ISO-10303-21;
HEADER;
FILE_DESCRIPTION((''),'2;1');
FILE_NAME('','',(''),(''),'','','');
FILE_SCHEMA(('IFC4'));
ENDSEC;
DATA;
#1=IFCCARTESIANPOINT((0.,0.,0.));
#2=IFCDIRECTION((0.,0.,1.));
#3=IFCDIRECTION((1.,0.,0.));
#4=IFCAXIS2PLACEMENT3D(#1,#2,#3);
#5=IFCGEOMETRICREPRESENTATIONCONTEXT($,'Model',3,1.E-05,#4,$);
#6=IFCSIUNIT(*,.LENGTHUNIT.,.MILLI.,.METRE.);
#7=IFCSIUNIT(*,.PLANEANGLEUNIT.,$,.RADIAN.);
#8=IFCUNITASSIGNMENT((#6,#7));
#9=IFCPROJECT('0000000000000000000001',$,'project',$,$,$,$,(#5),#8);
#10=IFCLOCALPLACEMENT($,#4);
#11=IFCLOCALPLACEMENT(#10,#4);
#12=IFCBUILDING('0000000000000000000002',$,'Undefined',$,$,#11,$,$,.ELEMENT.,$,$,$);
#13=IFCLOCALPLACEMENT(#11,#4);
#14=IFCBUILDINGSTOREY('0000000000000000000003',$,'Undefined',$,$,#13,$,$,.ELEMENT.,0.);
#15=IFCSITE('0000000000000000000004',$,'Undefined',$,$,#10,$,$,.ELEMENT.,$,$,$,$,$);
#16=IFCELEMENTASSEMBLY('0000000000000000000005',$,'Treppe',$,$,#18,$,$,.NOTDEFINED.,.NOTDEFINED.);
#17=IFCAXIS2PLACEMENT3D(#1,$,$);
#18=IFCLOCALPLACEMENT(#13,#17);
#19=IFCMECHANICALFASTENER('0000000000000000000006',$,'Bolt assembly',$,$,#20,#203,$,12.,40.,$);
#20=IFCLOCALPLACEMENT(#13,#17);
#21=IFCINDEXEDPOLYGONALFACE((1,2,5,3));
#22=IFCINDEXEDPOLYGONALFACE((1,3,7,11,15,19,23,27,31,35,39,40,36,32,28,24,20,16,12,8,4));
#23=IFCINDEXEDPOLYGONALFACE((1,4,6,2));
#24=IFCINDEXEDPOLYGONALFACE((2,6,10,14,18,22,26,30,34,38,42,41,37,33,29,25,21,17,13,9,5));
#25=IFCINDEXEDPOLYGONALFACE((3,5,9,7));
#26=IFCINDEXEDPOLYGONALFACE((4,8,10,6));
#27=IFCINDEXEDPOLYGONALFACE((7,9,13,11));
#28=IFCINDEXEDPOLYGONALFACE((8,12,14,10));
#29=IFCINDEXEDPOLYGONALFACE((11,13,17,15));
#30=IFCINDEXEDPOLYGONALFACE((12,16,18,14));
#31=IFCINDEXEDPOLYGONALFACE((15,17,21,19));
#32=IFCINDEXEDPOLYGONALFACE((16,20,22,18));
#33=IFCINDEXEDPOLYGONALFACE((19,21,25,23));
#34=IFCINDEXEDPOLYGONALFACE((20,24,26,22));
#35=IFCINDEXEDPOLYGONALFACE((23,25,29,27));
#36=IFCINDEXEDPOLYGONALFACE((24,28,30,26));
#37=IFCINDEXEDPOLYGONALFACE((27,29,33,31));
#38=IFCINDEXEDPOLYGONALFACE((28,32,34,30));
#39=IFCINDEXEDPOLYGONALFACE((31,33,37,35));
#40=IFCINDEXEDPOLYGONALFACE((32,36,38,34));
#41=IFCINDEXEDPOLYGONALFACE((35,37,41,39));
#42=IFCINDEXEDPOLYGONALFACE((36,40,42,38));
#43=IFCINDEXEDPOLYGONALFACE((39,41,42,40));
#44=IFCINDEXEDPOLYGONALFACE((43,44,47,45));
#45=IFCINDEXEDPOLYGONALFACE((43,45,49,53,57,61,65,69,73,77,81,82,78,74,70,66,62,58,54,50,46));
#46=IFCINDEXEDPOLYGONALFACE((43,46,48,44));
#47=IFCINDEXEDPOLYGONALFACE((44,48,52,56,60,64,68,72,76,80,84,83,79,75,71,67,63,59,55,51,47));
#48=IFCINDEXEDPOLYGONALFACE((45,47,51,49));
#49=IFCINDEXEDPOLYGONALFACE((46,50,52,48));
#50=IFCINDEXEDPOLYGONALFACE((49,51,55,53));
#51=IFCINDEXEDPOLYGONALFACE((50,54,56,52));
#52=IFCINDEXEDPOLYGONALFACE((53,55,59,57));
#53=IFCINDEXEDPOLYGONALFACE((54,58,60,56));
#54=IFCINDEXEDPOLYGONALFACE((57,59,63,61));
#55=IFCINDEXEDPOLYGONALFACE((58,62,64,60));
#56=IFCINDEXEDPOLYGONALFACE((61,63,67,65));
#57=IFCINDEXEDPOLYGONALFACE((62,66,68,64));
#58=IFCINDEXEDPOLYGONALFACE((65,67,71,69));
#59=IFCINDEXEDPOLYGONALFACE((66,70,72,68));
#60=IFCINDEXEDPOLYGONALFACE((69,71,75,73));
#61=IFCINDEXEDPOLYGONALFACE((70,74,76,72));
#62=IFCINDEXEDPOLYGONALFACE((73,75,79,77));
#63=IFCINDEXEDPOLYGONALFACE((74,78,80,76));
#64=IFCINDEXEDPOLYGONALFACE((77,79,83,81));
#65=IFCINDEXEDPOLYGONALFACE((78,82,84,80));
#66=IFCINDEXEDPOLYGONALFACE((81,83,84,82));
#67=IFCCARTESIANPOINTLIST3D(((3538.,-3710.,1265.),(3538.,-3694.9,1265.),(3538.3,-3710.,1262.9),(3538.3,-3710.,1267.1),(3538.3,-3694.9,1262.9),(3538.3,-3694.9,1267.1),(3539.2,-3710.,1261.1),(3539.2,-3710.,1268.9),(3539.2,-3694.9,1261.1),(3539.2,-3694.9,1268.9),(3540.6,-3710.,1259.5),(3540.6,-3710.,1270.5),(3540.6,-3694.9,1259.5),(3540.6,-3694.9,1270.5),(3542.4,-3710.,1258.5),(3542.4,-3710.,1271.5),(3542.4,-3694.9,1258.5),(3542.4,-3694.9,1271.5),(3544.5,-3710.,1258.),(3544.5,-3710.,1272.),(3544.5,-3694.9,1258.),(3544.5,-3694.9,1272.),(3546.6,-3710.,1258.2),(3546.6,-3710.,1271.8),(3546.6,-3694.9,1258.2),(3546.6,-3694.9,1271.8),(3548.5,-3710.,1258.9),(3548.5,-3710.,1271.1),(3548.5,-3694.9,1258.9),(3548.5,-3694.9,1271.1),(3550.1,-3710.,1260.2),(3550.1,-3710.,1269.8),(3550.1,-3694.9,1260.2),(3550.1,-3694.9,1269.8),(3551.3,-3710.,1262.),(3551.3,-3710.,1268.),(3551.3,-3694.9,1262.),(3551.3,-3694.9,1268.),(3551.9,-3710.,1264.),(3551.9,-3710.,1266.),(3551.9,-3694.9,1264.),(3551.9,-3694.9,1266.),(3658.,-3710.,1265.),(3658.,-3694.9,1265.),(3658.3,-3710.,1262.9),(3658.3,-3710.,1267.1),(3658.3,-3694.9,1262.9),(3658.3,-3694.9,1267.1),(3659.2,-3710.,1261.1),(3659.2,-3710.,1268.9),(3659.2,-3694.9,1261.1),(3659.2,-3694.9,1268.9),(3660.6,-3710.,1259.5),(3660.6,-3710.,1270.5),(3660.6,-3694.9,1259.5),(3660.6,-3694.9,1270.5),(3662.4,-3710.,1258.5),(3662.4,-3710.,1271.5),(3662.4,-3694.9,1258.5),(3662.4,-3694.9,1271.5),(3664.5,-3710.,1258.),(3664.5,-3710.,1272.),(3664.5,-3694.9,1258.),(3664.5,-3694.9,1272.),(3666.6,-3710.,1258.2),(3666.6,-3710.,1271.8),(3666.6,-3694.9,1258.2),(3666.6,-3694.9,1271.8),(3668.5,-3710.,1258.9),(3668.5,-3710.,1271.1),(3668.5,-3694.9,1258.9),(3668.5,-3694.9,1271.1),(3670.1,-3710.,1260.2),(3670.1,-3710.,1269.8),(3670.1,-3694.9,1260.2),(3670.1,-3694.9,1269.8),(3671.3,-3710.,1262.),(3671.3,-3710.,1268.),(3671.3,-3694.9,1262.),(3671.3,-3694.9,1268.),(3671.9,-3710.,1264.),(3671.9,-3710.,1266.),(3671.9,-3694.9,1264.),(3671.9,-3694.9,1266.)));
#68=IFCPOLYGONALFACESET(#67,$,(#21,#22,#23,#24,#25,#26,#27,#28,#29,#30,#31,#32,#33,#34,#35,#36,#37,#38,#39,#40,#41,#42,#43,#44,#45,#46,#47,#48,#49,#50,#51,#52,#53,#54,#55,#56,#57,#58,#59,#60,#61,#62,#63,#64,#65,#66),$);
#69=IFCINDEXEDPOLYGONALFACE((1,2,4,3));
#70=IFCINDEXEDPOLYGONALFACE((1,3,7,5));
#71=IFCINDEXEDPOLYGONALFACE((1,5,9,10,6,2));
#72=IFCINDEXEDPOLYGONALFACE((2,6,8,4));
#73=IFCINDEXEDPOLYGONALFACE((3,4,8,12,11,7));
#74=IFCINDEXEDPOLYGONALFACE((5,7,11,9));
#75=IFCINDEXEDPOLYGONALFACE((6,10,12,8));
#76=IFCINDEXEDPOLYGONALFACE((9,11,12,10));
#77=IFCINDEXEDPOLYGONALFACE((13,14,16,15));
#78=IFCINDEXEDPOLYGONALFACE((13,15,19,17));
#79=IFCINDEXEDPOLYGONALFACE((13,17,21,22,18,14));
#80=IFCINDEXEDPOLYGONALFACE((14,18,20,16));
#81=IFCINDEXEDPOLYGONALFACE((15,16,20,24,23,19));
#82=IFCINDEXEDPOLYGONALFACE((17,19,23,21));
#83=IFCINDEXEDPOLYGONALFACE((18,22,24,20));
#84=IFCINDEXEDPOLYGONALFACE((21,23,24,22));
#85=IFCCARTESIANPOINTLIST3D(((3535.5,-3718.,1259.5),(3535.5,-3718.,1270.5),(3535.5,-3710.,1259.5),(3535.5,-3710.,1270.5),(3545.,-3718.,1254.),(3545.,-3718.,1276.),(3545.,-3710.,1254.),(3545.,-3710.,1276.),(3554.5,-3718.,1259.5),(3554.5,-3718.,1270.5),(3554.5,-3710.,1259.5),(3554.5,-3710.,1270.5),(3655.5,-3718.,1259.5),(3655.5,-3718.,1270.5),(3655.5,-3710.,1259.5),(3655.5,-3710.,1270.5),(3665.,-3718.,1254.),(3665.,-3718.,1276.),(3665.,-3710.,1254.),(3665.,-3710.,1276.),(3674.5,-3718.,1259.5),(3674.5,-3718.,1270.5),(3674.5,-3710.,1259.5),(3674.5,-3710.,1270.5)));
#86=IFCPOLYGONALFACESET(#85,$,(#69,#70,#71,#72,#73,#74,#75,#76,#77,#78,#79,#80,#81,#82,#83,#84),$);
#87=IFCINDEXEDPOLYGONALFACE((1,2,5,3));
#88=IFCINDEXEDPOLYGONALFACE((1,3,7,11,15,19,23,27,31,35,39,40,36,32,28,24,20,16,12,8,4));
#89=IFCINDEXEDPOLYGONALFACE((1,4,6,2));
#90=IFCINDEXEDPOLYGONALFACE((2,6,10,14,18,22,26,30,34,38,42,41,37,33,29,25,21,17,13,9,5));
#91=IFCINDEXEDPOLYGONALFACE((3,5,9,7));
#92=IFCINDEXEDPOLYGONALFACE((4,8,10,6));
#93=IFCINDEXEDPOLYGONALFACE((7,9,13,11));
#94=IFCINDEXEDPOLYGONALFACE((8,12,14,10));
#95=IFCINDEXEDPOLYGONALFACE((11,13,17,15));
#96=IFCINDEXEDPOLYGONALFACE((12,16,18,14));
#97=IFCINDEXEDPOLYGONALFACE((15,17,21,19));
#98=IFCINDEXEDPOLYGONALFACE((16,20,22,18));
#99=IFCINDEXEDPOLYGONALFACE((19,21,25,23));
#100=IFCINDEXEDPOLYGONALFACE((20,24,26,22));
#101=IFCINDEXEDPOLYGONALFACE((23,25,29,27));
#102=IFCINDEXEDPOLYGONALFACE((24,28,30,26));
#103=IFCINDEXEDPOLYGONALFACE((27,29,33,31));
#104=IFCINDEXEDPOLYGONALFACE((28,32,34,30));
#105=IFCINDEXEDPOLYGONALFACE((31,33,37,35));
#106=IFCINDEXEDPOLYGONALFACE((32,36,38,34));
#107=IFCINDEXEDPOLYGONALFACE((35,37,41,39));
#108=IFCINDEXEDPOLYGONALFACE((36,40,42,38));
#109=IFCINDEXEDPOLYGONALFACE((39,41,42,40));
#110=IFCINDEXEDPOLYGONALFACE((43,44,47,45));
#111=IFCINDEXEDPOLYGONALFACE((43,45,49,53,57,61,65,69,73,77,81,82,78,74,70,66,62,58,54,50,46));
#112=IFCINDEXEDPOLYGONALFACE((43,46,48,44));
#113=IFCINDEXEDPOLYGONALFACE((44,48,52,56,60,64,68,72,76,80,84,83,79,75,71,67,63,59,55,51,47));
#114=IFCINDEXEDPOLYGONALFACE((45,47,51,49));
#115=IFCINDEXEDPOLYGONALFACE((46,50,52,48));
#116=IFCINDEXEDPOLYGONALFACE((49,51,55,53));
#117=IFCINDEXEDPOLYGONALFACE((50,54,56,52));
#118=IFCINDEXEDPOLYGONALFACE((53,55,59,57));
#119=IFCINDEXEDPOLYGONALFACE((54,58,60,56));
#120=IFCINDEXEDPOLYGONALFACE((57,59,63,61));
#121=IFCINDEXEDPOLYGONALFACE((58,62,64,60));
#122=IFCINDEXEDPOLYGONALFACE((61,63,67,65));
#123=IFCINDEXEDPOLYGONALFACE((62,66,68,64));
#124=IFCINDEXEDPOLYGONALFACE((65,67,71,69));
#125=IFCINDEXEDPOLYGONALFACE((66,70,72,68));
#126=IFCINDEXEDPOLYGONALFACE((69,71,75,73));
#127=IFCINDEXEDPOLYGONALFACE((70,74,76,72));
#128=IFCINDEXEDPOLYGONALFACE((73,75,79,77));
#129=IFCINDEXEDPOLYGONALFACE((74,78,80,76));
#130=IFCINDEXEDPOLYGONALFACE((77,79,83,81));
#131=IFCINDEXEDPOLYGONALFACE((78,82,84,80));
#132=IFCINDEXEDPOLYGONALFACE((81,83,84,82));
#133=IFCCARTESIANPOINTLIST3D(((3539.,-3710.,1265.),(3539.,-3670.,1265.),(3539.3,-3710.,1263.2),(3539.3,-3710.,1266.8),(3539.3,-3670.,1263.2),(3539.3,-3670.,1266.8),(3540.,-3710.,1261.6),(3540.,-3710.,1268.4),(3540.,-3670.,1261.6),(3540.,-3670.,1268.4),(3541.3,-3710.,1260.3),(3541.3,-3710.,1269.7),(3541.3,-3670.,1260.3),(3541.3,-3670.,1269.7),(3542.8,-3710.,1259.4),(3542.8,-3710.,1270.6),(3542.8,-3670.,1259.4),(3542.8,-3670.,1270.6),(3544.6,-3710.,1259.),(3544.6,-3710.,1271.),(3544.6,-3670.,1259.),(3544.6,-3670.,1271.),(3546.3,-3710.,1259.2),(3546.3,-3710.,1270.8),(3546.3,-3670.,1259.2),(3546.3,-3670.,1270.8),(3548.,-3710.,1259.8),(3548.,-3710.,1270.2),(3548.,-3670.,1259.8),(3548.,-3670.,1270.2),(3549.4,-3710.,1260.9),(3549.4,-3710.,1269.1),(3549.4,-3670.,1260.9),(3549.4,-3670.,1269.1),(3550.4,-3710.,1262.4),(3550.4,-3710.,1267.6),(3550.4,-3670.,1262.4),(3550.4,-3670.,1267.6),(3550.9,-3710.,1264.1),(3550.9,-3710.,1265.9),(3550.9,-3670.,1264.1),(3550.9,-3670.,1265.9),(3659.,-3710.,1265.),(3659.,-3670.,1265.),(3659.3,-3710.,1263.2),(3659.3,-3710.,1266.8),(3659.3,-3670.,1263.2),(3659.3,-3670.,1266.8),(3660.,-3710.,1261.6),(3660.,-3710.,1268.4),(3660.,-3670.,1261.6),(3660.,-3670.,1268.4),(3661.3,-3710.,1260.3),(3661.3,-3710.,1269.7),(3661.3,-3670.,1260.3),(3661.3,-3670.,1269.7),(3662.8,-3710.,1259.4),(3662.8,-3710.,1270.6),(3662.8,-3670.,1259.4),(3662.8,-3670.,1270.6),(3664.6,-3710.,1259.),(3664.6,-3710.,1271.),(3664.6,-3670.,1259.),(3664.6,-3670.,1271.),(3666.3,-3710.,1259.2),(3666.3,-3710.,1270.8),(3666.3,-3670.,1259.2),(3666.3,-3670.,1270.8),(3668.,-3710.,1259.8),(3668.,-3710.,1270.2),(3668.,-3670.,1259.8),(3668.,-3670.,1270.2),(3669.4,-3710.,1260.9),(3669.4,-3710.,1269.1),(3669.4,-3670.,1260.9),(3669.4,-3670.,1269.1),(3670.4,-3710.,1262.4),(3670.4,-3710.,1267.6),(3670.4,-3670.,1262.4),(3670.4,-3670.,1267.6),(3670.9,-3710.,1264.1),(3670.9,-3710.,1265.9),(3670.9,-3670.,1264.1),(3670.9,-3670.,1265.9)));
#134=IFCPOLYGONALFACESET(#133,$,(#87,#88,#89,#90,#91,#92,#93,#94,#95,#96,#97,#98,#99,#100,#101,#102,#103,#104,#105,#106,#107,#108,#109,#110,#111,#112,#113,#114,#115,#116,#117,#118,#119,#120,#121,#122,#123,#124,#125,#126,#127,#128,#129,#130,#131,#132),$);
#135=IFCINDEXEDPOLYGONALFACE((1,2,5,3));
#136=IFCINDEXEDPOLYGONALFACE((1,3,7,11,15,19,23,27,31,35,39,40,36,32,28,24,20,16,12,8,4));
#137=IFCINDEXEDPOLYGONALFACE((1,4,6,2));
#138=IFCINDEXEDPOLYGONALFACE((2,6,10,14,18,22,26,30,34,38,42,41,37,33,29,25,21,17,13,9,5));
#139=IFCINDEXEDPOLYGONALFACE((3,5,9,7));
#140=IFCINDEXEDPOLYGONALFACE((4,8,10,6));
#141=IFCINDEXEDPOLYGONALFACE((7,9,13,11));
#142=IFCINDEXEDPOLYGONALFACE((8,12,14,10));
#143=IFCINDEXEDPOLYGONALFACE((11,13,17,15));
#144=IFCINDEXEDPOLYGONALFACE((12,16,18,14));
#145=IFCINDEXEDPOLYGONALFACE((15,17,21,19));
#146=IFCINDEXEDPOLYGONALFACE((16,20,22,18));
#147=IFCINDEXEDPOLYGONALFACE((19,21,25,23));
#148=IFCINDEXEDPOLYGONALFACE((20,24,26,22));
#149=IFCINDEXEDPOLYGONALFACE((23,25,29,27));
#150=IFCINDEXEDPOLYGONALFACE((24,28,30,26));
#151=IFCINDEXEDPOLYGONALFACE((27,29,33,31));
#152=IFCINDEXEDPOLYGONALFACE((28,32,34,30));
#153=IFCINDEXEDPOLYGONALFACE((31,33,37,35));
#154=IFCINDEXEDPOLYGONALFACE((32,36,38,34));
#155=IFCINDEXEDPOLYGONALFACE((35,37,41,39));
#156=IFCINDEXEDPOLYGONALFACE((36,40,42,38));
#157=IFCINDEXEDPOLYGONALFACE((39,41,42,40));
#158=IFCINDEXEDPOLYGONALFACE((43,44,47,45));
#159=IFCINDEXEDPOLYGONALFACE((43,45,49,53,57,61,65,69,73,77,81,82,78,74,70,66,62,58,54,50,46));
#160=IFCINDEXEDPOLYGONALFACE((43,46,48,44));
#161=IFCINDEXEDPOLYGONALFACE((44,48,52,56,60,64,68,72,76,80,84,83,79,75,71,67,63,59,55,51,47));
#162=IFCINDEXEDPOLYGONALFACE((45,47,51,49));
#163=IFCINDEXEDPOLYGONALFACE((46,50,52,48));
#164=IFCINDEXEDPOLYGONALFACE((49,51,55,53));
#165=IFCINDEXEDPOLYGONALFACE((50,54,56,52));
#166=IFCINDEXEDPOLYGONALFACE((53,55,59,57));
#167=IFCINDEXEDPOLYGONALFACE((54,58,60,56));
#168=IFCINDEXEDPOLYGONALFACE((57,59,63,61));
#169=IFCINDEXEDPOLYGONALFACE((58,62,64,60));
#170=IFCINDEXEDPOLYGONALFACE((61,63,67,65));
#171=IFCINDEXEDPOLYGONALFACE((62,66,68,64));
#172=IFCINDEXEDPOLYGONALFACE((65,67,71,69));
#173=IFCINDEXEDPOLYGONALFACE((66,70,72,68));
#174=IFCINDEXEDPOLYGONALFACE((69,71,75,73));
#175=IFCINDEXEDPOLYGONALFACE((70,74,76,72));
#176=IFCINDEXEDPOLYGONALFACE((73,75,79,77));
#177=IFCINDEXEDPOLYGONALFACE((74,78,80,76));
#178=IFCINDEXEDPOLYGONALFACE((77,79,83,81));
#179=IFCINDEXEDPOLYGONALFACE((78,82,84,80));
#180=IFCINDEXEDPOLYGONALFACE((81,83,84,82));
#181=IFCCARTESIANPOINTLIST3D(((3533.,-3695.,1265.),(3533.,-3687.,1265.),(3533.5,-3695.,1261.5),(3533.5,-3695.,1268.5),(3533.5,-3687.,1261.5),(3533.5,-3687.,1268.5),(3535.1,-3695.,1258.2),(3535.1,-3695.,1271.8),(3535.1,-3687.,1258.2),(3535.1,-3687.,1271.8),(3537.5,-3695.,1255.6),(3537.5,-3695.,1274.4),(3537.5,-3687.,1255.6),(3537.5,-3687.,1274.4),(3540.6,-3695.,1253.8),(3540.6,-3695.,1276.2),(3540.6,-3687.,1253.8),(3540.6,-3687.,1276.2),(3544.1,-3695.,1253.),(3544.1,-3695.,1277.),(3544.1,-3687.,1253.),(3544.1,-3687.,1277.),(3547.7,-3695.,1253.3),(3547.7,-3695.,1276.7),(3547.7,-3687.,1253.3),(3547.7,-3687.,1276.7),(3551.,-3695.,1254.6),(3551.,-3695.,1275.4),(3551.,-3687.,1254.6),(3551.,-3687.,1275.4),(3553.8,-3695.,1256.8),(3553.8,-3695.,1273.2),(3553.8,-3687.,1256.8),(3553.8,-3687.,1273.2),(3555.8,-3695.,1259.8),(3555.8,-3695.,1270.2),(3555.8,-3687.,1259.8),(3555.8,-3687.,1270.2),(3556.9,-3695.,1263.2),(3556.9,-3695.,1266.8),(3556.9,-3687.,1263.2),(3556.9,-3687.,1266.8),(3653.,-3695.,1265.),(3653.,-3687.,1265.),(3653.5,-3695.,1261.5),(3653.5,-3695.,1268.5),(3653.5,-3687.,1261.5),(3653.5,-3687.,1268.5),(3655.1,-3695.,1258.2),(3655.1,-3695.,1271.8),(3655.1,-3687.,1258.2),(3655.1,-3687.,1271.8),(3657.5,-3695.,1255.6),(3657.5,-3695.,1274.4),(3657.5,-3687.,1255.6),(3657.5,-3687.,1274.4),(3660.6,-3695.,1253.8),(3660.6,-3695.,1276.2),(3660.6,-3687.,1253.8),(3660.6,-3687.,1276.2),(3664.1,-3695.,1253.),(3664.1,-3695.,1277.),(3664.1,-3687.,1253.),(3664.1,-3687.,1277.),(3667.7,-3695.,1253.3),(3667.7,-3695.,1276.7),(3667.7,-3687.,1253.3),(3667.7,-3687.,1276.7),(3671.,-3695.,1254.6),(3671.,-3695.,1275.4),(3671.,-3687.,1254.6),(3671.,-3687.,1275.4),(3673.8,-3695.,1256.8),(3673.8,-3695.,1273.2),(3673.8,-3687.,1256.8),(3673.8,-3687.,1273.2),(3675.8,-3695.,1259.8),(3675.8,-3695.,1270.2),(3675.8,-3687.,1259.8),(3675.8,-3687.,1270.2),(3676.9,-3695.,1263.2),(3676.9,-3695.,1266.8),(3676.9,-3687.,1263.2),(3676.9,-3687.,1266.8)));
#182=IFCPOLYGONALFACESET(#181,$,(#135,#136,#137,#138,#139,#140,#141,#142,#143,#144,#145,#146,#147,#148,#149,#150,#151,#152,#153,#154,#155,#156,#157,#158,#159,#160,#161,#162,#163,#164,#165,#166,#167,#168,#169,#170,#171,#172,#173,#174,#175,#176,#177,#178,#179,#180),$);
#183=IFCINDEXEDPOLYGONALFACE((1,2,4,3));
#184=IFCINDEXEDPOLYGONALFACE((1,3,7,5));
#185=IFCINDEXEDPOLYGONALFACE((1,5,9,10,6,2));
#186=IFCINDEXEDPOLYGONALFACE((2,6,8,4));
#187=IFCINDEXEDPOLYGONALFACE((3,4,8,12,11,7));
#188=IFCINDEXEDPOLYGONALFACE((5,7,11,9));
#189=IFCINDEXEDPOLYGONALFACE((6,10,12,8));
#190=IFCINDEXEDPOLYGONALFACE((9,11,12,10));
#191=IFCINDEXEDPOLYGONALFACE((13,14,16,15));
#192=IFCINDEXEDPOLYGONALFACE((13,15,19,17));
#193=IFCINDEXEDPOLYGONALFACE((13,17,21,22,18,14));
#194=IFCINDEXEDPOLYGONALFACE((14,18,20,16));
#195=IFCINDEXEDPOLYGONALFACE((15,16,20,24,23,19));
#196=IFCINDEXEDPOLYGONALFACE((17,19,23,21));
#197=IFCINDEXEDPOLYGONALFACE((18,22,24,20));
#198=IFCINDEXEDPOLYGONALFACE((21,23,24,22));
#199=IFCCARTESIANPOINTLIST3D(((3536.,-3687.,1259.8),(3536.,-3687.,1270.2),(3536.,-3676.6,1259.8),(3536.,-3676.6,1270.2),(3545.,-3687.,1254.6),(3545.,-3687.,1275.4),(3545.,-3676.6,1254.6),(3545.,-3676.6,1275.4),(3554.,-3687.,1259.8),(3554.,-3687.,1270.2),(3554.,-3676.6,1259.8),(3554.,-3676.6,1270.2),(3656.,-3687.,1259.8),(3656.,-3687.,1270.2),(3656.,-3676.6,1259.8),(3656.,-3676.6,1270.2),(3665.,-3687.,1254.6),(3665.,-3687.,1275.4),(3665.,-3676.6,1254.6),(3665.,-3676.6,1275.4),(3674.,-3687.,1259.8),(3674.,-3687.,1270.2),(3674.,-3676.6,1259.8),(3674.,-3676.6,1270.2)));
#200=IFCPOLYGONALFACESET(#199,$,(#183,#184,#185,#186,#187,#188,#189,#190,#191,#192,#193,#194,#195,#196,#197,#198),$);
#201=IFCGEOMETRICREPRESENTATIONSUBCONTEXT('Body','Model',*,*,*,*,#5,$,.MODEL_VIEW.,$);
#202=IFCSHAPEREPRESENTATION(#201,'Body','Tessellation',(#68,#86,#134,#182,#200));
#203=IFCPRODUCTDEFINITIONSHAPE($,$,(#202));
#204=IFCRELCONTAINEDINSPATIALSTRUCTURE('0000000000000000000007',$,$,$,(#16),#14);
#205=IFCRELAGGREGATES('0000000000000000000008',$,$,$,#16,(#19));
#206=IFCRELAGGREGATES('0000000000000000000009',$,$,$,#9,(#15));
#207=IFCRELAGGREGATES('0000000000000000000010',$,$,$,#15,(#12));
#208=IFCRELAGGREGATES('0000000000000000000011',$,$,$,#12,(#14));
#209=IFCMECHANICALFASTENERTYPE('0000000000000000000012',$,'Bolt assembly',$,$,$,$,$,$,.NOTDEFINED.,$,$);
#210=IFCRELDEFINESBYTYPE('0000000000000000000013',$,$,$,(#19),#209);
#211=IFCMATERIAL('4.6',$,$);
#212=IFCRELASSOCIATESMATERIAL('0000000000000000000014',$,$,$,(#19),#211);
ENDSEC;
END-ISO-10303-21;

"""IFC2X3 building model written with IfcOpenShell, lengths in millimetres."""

from ifc_helpers import new_model, si_unit, frame, origin_with_axes, origin_2d_with_axis, place, context, subcontext, project, spatial, polyline, circle, outline, extrude, source, transform, mapped, material, type_object, element, aggregate, save


model = new_model("IFC2X3")

# Units and contexts
model_context = context("Model", 3, precision=1e-05, world=origin_with_axes())
body_context = subcontext(model_context, "Body", "Model", "MODEL_VIEW")
ifc_project = project(units=[si_unit("LENGTHUNIT", "METRE", prefix="MILLI"), si_unit("PLANEANGLEUNIT", "RADIAN")], contexts=[model_context])

# Site, building, storey
site_placement = place(None, origin_with_axes())
site = spatial("IfcSite", under=ifc_project, at=site_placement, Name="Undefined", CompositionType="ELEMENT")
building_placement = place(site_placement, origin_with_axes())
building = spatial("IfcBuilding", under=site, at=building_placement, Name="Undefined", CompositionType="ELEMENT")
storey_placement = place(building_placement, origin_with_axes())
storey = spatial("IfcBuildingStorey", under=building, at=storey_placement, Name="Undefined", CompositionType="ELEMENT", Elevation=0.0)

# Element assembly, mechanical fastener
assembly_1_placement = place(storey_placement, origin_with_axes())
assembly_1 = element("IfcElementAssembly", 1, at=assembly_1_placement, inside=storey, Name="Treppe", AssemblyPlace="NOTDEFINED", PredefinedType="NOTDEFINED")
ifc_material_1 = material(Name="4.6")
mechanical_fastener_type = type_object("IfcMechanicalFastenerType", Name="Bolt assembly")
shared_shape_1 = source(origin_with_axes(), body_context, "Body", "SweptSolid", [
    extrude(circle(Radius=7.0, at=origin_2d_with_axis()), frame((0.0, 0.0, 0.0), z_axis=(0.0, 1.0, 0.0), x_axis=(1.0, 0.0, 0.0)), (0.0, 0.0, 1.0), 15.1),
    extrude(outline(polyline([(9.5, -5.5), (9.5, 5.5), (0.0, 11.0), (-9.5, 5.5), (-9.5, -5.5), (0.0, -11.0), (9.5, -5.5)])), frame((0.0, -8.0, 0.0), z_axis=(0.0, 1.0, 0.0), x_axis=(1.0, 0.0, 0.0)), (0.0, 0.0, 1.0), 8.0),
    extrude(circle(Radius=6.0, at=origin_2d_with_axis()), frame((0.0, 0.0, 0.0), z_axis=(0.0, 1.0, 0.0), x_axis=(1.0, 0.0, 0.0)), (0.0, 0.0, 1.0), 40.0),
    extrude(circle(Radius=12.0, at=origin_2d_with_axis()), frame((0.0, 15.0, 0.0), z_axis=(0.0, 1.0, 0.0), x_axis=(1.0, 0.0, 0.0)), (0.0, 0.0, 1.0), 8.0),
    extrude(outline(polyline([(9.0, -5.2), (9.0, 5.2), (0.0, 10.4), (-9.0, 5.2), (-9.0, -5.2), (0.0, -10.4), (9.0, -5.2)])), frame((0.0, 23.0, 0.0), z_axis=(0.0, 1.0, 0.0), x_axis=(1.0, 0.0, 0.0)), (0.0, 0.0, 1.0), 10.4),
])
mechanical_fastener_1_placement = place(assembly_1_placement, frame((3665.0, -3710.0, 1265.0), z_axis=(0.0, 0.0, -1.0), x_axis=(-1.0, 0.0, 0.0)))
mechanical_fastener_1 = element("IfcMechanicalFastener", 2, at=mechanical_fastener_1_placement, type_object=mechanical_fastener_type, material=ifc_material_1, Name="Bolt assembly", NominalDiameter=12.0, NominalLength=40.0, context=body_context, shape_type="MappedRepresentation", body=[
    mapped(shared_shape_1, transform((0.0, 0.0, 0.0))),
    mapped(shared_shape_1, transform((120.0, 0.0, 0.0))),
])
aggregate(assembly_1, [mechanical_fastener_1])

save(model, "model.ifc")
